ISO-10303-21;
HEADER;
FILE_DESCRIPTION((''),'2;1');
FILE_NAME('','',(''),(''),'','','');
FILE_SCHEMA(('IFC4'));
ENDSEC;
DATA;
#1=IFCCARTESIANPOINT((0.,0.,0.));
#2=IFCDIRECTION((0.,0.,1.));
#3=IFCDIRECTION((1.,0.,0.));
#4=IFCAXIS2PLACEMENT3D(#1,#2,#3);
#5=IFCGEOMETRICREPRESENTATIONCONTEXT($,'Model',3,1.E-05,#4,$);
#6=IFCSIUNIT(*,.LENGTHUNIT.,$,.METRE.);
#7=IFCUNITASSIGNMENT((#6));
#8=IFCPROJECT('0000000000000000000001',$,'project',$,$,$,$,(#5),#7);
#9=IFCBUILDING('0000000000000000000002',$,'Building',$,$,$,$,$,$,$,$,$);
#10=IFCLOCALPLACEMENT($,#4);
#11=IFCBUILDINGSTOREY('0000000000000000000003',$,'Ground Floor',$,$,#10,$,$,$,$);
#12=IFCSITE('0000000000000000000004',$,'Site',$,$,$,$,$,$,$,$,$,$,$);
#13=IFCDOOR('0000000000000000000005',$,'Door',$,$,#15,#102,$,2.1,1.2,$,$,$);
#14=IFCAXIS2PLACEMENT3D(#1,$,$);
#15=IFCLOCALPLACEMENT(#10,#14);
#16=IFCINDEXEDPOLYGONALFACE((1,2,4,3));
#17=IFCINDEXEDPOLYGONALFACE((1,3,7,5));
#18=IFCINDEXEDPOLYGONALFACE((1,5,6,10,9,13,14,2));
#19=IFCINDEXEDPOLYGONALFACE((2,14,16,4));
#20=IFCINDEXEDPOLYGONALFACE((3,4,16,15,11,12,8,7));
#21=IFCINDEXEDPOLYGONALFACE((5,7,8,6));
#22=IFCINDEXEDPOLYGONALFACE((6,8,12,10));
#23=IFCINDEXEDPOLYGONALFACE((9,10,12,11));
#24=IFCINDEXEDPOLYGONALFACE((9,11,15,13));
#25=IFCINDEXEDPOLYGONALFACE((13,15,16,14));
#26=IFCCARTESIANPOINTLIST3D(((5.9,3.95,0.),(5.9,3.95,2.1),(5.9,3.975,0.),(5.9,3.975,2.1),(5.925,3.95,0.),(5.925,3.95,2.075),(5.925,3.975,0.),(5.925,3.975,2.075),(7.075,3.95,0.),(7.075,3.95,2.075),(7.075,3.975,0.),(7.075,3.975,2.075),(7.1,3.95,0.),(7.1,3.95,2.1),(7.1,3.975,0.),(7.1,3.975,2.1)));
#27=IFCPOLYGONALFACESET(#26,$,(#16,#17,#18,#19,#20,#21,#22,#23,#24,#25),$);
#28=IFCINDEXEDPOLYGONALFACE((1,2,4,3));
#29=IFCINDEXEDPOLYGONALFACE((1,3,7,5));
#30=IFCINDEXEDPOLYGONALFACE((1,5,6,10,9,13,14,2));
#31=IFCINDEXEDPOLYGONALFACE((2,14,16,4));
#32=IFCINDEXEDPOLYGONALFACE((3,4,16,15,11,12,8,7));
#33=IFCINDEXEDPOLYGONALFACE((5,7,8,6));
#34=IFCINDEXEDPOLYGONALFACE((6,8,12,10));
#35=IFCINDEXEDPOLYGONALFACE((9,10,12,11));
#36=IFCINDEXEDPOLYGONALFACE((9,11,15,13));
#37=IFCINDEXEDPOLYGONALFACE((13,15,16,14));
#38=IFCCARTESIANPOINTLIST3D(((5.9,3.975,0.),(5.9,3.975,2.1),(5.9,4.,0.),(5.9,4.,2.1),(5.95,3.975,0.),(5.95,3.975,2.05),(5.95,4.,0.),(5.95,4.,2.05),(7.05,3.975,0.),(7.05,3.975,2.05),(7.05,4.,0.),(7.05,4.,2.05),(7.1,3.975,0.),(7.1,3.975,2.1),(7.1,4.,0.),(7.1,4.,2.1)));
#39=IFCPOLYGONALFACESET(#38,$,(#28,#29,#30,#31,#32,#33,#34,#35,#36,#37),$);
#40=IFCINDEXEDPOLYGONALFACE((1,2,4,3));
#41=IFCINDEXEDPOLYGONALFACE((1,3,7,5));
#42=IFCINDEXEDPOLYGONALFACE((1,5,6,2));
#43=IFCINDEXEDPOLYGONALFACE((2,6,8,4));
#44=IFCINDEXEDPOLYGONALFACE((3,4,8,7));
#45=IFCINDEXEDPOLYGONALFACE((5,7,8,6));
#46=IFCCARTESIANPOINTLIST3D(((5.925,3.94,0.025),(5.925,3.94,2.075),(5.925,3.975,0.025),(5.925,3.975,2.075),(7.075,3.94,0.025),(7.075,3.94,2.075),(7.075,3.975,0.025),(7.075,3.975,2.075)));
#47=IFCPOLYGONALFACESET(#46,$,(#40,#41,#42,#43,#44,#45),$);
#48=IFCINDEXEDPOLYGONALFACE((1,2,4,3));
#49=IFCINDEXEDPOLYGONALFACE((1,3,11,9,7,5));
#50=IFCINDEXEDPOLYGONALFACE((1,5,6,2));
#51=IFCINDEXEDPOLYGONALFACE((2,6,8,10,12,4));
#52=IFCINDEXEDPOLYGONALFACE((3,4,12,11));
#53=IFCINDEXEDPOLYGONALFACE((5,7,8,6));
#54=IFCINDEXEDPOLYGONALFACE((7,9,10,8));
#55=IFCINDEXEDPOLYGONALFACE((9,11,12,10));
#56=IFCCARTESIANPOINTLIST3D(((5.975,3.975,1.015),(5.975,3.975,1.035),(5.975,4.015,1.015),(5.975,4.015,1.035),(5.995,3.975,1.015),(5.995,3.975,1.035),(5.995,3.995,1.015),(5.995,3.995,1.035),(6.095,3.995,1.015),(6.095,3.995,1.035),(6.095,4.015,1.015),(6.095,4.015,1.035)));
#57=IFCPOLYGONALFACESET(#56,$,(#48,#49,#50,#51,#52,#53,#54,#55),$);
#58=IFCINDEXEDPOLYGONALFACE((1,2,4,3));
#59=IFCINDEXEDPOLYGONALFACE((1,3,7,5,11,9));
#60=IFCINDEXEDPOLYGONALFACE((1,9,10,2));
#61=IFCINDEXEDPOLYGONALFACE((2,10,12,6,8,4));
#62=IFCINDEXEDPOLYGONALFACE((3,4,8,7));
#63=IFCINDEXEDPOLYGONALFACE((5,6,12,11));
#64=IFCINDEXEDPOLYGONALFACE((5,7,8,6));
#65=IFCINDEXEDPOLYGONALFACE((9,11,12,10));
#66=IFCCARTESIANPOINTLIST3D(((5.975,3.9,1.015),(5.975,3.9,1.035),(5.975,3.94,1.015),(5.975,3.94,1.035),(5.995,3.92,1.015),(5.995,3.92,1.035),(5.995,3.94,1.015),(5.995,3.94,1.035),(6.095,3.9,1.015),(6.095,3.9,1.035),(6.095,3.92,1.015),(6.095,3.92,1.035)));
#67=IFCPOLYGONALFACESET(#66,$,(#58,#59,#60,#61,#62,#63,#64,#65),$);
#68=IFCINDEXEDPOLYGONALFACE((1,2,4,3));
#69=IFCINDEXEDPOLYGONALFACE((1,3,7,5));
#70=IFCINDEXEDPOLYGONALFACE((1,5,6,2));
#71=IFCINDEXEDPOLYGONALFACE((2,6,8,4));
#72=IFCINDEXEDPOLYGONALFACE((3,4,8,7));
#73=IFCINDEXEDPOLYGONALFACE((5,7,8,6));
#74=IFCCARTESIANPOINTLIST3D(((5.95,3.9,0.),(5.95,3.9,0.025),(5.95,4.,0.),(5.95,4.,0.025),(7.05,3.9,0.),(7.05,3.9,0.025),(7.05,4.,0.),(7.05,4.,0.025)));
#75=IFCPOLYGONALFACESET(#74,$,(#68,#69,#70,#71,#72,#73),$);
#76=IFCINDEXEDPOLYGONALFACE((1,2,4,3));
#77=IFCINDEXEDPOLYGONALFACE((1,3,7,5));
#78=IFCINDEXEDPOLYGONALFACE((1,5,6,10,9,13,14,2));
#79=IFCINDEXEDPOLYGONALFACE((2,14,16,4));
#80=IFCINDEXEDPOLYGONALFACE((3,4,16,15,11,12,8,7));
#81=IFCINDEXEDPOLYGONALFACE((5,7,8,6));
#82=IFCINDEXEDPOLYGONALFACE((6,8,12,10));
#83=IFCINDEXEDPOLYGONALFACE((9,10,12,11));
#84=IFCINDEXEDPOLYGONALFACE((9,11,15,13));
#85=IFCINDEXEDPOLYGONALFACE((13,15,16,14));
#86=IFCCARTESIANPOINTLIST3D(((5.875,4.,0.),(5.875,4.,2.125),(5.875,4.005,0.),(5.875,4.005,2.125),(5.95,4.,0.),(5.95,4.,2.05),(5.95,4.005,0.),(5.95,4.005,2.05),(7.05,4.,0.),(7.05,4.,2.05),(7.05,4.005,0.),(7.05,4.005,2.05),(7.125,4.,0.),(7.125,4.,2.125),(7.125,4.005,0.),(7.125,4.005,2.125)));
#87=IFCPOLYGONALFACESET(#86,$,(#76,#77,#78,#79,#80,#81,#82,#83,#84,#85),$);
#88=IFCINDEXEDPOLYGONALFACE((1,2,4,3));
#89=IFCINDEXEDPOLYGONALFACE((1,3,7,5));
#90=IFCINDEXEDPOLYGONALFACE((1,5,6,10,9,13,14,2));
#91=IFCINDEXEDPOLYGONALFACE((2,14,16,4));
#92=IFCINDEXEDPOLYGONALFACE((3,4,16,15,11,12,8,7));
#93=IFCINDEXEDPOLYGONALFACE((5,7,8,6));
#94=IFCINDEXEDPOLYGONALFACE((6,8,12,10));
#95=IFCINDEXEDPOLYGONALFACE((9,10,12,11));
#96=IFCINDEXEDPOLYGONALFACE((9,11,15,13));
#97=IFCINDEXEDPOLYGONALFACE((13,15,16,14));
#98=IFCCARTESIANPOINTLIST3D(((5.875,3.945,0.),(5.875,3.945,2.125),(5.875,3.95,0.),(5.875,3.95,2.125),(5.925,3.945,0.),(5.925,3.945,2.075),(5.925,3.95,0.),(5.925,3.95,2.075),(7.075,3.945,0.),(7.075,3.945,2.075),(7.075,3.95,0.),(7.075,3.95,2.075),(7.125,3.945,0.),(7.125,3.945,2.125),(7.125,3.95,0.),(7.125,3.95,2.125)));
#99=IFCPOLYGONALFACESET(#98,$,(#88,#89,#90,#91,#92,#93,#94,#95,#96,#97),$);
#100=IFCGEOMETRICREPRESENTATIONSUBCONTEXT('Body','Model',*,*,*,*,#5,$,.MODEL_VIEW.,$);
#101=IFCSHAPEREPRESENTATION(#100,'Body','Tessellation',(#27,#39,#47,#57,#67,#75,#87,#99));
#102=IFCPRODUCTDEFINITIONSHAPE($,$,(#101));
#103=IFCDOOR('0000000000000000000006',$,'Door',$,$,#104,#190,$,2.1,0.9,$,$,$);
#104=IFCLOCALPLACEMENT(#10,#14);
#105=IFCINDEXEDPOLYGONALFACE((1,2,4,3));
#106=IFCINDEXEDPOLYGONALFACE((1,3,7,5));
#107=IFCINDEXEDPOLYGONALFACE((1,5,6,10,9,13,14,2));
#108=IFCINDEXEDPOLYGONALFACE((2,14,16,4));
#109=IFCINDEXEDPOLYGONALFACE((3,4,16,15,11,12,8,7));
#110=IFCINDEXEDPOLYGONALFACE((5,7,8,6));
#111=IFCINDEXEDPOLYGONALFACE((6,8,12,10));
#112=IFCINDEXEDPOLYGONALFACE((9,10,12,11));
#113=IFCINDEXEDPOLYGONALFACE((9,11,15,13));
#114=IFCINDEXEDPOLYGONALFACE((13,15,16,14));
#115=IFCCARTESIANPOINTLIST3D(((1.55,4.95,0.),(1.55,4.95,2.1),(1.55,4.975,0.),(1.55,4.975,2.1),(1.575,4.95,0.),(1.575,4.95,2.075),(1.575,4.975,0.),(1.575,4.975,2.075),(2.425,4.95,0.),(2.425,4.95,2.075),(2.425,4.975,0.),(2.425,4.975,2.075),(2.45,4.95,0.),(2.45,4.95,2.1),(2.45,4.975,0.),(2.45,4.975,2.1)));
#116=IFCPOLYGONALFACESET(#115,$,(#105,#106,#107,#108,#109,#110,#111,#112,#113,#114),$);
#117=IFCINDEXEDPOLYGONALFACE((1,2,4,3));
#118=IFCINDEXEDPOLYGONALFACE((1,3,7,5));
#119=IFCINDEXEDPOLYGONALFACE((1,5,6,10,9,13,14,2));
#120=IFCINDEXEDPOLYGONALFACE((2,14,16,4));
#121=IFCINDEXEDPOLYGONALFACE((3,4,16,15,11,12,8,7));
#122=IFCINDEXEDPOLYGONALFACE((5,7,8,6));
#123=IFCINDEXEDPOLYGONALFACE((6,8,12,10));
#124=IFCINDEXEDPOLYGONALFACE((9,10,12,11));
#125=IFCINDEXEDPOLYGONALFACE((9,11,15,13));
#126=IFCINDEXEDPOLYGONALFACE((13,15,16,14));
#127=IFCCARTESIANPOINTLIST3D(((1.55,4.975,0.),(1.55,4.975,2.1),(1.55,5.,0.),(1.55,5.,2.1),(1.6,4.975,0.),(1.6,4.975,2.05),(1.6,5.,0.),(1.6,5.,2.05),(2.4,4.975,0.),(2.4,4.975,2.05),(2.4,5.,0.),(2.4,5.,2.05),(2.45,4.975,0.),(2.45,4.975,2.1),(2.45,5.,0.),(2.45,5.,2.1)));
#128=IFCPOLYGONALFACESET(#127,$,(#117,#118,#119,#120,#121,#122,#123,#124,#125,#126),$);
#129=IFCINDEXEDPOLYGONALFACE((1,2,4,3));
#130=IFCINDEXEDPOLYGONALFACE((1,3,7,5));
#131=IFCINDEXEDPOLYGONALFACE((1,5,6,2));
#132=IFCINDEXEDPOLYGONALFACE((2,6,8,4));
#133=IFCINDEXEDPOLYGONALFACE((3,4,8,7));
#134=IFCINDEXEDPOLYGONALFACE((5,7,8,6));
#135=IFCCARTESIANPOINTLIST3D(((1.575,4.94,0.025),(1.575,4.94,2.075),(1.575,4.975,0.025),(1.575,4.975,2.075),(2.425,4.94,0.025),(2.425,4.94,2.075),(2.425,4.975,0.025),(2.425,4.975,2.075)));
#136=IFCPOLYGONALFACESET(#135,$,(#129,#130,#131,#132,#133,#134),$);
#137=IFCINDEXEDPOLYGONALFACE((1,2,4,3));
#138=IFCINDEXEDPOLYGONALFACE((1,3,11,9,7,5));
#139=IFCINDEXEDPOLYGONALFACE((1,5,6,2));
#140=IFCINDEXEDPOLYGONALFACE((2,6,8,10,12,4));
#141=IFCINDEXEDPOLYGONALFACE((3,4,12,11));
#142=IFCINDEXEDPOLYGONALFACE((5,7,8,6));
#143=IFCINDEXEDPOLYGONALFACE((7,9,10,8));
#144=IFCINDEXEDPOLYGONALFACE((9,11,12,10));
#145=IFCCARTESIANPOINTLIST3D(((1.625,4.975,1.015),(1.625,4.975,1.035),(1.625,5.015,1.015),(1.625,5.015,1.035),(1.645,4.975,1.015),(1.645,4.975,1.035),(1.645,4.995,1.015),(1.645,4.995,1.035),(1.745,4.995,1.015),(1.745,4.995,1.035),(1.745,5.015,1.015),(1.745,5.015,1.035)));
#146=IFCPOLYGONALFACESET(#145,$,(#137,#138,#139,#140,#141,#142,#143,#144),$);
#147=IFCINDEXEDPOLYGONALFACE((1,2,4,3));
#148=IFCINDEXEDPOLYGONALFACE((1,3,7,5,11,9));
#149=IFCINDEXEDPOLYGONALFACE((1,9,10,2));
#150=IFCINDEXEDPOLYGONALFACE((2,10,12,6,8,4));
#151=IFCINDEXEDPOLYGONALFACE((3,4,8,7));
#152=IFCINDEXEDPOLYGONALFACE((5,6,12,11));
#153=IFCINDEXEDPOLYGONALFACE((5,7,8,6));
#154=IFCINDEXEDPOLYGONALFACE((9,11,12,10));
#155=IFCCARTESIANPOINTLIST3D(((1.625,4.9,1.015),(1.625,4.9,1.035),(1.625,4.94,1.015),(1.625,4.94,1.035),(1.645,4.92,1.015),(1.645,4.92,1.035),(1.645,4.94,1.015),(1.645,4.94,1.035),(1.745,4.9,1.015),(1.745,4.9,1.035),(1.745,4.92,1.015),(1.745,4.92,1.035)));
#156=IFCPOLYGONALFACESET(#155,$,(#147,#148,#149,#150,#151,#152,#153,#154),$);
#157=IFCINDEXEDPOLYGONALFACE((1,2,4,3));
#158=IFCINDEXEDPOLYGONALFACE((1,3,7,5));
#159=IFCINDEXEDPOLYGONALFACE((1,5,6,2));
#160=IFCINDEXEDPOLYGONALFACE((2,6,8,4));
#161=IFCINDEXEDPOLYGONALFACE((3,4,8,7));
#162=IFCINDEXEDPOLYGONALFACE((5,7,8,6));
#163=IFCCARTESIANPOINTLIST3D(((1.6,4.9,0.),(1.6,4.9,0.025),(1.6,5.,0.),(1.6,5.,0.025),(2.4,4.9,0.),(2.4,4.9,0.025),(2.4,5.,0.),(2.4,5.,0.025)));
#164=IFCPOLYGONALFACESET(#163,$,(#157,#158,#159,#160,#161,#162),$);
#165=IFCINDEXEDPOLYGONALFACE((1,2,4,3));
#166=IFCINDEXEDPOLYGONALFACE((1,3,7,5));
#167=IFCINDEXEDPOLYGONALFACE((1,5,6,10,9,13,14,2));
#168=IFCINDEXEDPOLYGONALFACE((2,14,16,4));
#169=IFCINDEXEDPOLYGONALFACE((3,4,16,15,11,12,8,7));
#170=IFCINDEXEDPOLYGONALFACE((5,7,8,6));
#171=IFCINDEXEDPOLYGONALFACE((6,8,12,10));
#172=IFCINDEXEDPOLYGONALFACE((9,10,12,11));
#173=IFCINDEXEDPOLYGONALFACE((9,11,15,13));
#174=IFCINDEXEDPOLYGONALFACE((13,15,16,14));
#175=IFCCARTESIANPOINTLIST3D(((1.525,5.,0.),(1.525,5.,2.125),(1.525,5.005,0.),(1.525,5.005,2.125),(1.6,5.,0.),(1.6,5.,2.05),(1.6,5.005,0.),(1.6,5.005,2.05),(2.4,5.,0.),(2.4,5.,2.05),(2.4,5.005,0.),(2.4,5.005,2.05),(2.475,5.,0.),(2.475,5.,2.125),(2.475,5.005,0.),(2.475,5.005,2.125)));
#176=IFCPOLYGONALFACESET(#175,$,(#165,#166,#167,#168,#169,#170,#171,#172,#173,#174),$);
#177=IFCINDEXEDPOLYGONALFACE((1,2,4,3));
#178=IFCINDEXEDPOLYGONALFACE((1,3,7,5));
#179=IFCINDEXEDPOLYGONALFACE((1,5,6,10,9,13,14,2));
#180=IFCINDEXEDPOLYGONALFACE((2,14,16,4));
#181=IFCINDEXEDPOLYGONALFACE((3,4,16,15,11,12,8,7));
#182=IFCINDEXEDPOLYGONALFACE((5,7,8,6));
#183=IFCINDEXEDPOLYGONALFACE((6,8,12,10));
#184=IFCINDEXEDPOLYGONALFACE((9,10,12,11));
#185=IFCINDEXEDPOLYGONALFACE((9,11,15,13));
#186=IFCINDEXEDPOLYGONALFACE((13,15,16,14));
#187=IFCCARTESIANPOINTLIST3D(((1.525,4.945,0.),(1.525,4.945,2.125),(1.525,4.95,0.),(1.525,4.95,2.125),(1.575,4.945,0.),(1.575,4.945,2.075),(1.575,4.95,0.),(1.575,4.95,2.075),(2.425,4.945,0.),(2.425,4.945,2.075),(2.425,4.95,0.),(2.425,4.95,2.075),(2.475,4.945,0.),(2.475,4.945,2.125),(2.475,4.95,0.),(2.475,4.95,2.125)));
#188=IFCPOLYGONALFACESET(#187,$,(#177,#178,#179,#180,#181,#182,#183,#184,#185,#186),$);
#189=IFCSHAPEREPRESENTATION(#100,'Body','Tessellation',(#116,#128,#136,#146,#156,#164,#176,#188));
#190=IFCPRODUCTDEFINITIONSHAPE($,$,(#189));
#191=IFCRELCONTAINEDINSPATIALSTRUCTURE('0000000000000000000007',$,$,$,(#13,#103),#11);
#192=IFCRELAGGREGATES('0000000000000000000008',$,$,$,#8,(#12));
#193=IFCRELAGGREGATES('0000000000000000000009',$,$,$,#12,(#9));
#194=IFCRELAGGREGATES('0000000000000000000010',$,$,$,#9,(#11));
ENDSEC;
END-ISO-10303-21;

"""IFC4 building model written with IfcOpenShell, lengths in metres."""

from ifc_helpers import new_model, si_unit, frame, origin_with_axes, place, context, subcontext, project, spatial, line, indexed_curve, outline, extrude, element, save


model = new_model("IFC4")

# Units and contexts
model_context = context("Model", 3, precision=1e-05, world=origin_with_axes())
body_context = subcontext(model_context, "Body", "Model", "MODEL_VIEW")
ifc_project = project(units=[si_unit("LENGTHUNIT", "METRE")], contexts=[model_context])

# Site, building, storey
site = spatial("IfcSite", under=ifc_project, Name="Site")
building = spatial("IfcBuilding", under=site, Name="Building")
storey_placement = place(None, origin_with_axes())
storey = spatial("IfcBuildingStorey", under=building, at=storey_placement, Name="Ground Floor")

# Doors
door_1_placement = place(storey_placement, frame((7.1, 4.0, 0.0), z_axis=(0.0, 0.0, 1.0), x_axis=(-1.0, 0.0, 0.0)))
element("IfcDoor", 1, at=door_1_placement, inside=storey, Name="Door", OverallHeight=2.1, OverallWidth=1.2, context=body_context, shape_type="SweptSolid", body=[
    extrude(outline(indexed_curve([(0.0, 0.0), (0.0, 2.1), (1.2, 2.1), (1.2, 0.0), (1.175, 0.0), (1.175, 2.075), (0.025, 2.075), (0.025, 0.0)], segments=[line(1, 2, 3, 4, 5, 6, 7, 8, 1)])), frame((0.0, 0.025, 0.0), z_axis=(0.0, -1.0, 0.0), x_axis=(1.0, 0.0, 0.0)), (0.0, 0.0, -1.0), 0.025),
    extrude(outline(indexed_curve([(0.0, 0.0), (0.0, 2.1), (1.2, 2.1), (1.2, 0.0), (1.15, 0.0), (1.15, 2.05), (0.05, 2.05), (0.05, 0.0)], segments=[line(1, 2, 3, 4, 5, 6, 7, 8, 1)])), frame((0.0, 0.0, 0.0), z_axis=(0.0, -1.0, 0.0), x_axis=(1.0, 0.0, 0.0)), (0.0, 0.0, -1.0), 0.025),
    extrude(outline(indexed_curve([(0.0, 0.0), (1.15, 0.0), (1.15, 0.035), (0.0, 0.035)], segments=[line(1, 2, 3, 4, 1)])), frame((0.025, 0.025, 0.025), z_axis=(0.0, 0.0, 1.0), x_axis=(1.0, 0.0, 0.0)), (0.0, 0.0, 1.0), 2.05),
    extrude(outline(indexed_curve([(0.0, 0.0), (0.0, -0.04), (-0.12, -0.04), (-0.12, -0.02), (-0.02, -0.02), (-0.02, 0.0)], segments=[line(1, 2, 3, 4, 5, 6, 1)])), frame((1.125, 0.025, 1.015), z_axis=(0.0, 0.0, 1.0), x_axis=(1.0, 0.0, 0.0)), (0.0, 0.0, 1.0), 0.02),
    extrude(outline(indexed_curve([(0.0, 0.0), (0.0, 0.04), (-0.12, 0.04), (-0.12, 0.02), (-0.02, 0.02), (-0.02, 0.0)], segments=[line(1, 2, 3, 4, 5, 6, 1)])), frame((1.125, 0.06, 1.015), z_axis=(0.0, 0.0, 1.0), x_axis=(1.0, 0.0, 0.0)), (0.0, 0.0, 1.0), 0.02),
    extrude(outline(indexed_curve([(0.0, 0.0), (1.1, 0.0), (1.1, 0.1), (0.0, 0.1)], segments=[line(1, 2, 3, 4, 1)])), frame((0.05, 0.0, 0.0), z_axis=(0.0, 0.0, 1.0), x_axis=(1.0, 0.0, 0.0)), (0.0, 0.0, 1.0), 0.025),
    extrude(outline(indexed_curve([(0.0, 0.0), (0.0, 2.125), (1.25, 2.125), (1.25, 0.0), (1.175, 0.0), (1.175, 2.05), (0.075, 2.05), (0.075, 0.0)], segments=[line(1, 2, 3, 4, 5, 6, 7, 8, 1)])), frame((-0.025, -0.005, 0.0), z_axis=(0.0, -1.0, 0.0), x_axis=(1.0, 0.0, 0.0)), (0.0, 0.0, -1.0), 0.005),
    extrude(outline(indexed_curve([(0.0, 0.0), (0.0, 2.125), (1.25, 2.125), (1.25, 0.0), (1.2, 0.0), (1.2, 2.075), (0.05, 2.075), (0.05, 0.0)], segments=[line(1, 2, 3, 4, 5, 6, 7, 8, 1)])), frame((-0.025, 0.05, 0.0), z_axis=(0.0, -1.0, 0.0), x_axis=(1.0, 0.0, 0.0)), (0.0, 0.0, -1.0), 0.005),
])
door_2_placement = place(storey_placement, frame((2.45, 5.0, 0.0), z_axis=(0.0, 0.0, 1.0), x_axis=(-1.0, 0.0, 0.0)))
element("IfcDoor", 2, at=door_2_placement, inside=storey, Name="Door", OverallHeight=2.1, OverallWidth=0.9, context=body_context, shape_type="SweptSolid", body=[
    extrude(outline(indexed_curve([(0.0, 0.0), (0.0, 2.1), (0.9, 2.1), (0.9, 0.0), (0.875, 0.0), (0.875, 2.075), (0.025, 2.075), (0.025, 0.0)], segments=[line(1, 2, 3, 4, 5, 6, 7, 8, 1)])), frame((0.0, 0.025, 0.0), z_axis=(0.0, -1.0, 0.0), x_axis=(1.0, 0.0, 0.0)), (0.0, 0.0, -1.0), 0.025),
    extrude(outline(indexed_curve([(0.0, 0.0), (0.0, 2.1), (0.9, 2.1), (0.9, 0.0), (0.85, 0.0), (0.85, 2.05), (0.05, 2.05), (0.05, 0.0)], segments=[line(1, 2, 3, 4, 5, 6, 7, 8, 1)])), frame((0.0, 0.0, 0.0), z_axis=(0.0, -1.0, 0.0), x_axis=(1.0, 0.0, 0.0)), (0.0, 0.0, -1.0), 0.025),
    extrude(outline(indexed_curve([(0.0, 0.0), (0.85, 0.0), (0.85, 0.035), (0.0, 0.035)], segments=[line(1, 2, 3, 4, 1)])), frame((0.025, 0.025, 0.025), z_axis=(0.0, 0.0, 1.0), x_axis=(1.0, 0.0, 0.0)), (0.0, 0.0, 1.0), 2.05),
    extrude(outline(indexed_curve([(0.0, 0.0), (0.0, -0.04), (-0.12, -0.04), (-0.12, -0.02), (-0.02, -0.02), (-0.02, 0.0)], segments=[line(1, 2, 3, 4, 5, 6, 1)])), frame((0.825, 0.025, 1.015), z_axis=(0.0, 0.0, 1.0), x_axis=(1.0, 0.0, 0.0)), (0.0, 0.0, 1.0), 0.02),
    extrude(outline(indexed_curve([(0.0, 0.0), (0.0, 0.04), (-0.12, 0.04), (-0.12, 0.02), (-0.02, 0.02), (-0.02, 0.0)], segments=[line(1, 2, 3, 4, 5, 6, 1)])), frame((0.825, 0.06, 1.015), z_axis=(0.0, 0.0, 1.0), x_axis=(1.0, 0.0, 0.0)), (0.0, 0.0, 1.0), 0.02),
    extrude(outline(indexed_curve([(0.0, 0.0), (0.8, 0.0), (0.8, 0.1), (0.0, 0.1)], segments=[line(1, 2, 3, 4, 1)])), frame((0.05, 0.0, 0.0), z_axis=(0.0, 0.0, 1.0), x_axis=(1.0, 0.0, 0.0)), (0.0, 0.0, 1.0), 0.025),
    extrude(outline(indexed_curve([(0.0, 0.0), (0.0, 2.125), (0.95, 2.125), (0.95, 0.0), (0.875, 0.0), (0.875, 2.05), (0.075, 2.05), (0.075, 0.0)], segments=[line(1, 2, 3, 4, 5, 6, 7, 8, 1)])), frame((-0.025, -0.005, 0.0), z_axis=(0.0, -1.0, 0.0), x_axis=(1.0, 0.0, 0.0)), (0.0, 0.0, -1.0), 0.005),
    extrude(outline(indexed_curve([(0.0, 0.0), (0.0, 2.125), (0.95, 2.125), (0.95, 0.0), (0.9, 0.0), (0.9, 2.075), (0.05, 2.075), (0.05, 0.0)], segments=[line(1, 2, 3, 4, 5, 6, 7, 8, 1)])), frame((-0.025, 0.05, 0.0), z_axis=(0.0, -1.0, 0.0), x_axis=(1.0, 0.0, 0.0)), (0.0, 0.0, -1.0), 0.005),
])

save(model, "model.ifc")
